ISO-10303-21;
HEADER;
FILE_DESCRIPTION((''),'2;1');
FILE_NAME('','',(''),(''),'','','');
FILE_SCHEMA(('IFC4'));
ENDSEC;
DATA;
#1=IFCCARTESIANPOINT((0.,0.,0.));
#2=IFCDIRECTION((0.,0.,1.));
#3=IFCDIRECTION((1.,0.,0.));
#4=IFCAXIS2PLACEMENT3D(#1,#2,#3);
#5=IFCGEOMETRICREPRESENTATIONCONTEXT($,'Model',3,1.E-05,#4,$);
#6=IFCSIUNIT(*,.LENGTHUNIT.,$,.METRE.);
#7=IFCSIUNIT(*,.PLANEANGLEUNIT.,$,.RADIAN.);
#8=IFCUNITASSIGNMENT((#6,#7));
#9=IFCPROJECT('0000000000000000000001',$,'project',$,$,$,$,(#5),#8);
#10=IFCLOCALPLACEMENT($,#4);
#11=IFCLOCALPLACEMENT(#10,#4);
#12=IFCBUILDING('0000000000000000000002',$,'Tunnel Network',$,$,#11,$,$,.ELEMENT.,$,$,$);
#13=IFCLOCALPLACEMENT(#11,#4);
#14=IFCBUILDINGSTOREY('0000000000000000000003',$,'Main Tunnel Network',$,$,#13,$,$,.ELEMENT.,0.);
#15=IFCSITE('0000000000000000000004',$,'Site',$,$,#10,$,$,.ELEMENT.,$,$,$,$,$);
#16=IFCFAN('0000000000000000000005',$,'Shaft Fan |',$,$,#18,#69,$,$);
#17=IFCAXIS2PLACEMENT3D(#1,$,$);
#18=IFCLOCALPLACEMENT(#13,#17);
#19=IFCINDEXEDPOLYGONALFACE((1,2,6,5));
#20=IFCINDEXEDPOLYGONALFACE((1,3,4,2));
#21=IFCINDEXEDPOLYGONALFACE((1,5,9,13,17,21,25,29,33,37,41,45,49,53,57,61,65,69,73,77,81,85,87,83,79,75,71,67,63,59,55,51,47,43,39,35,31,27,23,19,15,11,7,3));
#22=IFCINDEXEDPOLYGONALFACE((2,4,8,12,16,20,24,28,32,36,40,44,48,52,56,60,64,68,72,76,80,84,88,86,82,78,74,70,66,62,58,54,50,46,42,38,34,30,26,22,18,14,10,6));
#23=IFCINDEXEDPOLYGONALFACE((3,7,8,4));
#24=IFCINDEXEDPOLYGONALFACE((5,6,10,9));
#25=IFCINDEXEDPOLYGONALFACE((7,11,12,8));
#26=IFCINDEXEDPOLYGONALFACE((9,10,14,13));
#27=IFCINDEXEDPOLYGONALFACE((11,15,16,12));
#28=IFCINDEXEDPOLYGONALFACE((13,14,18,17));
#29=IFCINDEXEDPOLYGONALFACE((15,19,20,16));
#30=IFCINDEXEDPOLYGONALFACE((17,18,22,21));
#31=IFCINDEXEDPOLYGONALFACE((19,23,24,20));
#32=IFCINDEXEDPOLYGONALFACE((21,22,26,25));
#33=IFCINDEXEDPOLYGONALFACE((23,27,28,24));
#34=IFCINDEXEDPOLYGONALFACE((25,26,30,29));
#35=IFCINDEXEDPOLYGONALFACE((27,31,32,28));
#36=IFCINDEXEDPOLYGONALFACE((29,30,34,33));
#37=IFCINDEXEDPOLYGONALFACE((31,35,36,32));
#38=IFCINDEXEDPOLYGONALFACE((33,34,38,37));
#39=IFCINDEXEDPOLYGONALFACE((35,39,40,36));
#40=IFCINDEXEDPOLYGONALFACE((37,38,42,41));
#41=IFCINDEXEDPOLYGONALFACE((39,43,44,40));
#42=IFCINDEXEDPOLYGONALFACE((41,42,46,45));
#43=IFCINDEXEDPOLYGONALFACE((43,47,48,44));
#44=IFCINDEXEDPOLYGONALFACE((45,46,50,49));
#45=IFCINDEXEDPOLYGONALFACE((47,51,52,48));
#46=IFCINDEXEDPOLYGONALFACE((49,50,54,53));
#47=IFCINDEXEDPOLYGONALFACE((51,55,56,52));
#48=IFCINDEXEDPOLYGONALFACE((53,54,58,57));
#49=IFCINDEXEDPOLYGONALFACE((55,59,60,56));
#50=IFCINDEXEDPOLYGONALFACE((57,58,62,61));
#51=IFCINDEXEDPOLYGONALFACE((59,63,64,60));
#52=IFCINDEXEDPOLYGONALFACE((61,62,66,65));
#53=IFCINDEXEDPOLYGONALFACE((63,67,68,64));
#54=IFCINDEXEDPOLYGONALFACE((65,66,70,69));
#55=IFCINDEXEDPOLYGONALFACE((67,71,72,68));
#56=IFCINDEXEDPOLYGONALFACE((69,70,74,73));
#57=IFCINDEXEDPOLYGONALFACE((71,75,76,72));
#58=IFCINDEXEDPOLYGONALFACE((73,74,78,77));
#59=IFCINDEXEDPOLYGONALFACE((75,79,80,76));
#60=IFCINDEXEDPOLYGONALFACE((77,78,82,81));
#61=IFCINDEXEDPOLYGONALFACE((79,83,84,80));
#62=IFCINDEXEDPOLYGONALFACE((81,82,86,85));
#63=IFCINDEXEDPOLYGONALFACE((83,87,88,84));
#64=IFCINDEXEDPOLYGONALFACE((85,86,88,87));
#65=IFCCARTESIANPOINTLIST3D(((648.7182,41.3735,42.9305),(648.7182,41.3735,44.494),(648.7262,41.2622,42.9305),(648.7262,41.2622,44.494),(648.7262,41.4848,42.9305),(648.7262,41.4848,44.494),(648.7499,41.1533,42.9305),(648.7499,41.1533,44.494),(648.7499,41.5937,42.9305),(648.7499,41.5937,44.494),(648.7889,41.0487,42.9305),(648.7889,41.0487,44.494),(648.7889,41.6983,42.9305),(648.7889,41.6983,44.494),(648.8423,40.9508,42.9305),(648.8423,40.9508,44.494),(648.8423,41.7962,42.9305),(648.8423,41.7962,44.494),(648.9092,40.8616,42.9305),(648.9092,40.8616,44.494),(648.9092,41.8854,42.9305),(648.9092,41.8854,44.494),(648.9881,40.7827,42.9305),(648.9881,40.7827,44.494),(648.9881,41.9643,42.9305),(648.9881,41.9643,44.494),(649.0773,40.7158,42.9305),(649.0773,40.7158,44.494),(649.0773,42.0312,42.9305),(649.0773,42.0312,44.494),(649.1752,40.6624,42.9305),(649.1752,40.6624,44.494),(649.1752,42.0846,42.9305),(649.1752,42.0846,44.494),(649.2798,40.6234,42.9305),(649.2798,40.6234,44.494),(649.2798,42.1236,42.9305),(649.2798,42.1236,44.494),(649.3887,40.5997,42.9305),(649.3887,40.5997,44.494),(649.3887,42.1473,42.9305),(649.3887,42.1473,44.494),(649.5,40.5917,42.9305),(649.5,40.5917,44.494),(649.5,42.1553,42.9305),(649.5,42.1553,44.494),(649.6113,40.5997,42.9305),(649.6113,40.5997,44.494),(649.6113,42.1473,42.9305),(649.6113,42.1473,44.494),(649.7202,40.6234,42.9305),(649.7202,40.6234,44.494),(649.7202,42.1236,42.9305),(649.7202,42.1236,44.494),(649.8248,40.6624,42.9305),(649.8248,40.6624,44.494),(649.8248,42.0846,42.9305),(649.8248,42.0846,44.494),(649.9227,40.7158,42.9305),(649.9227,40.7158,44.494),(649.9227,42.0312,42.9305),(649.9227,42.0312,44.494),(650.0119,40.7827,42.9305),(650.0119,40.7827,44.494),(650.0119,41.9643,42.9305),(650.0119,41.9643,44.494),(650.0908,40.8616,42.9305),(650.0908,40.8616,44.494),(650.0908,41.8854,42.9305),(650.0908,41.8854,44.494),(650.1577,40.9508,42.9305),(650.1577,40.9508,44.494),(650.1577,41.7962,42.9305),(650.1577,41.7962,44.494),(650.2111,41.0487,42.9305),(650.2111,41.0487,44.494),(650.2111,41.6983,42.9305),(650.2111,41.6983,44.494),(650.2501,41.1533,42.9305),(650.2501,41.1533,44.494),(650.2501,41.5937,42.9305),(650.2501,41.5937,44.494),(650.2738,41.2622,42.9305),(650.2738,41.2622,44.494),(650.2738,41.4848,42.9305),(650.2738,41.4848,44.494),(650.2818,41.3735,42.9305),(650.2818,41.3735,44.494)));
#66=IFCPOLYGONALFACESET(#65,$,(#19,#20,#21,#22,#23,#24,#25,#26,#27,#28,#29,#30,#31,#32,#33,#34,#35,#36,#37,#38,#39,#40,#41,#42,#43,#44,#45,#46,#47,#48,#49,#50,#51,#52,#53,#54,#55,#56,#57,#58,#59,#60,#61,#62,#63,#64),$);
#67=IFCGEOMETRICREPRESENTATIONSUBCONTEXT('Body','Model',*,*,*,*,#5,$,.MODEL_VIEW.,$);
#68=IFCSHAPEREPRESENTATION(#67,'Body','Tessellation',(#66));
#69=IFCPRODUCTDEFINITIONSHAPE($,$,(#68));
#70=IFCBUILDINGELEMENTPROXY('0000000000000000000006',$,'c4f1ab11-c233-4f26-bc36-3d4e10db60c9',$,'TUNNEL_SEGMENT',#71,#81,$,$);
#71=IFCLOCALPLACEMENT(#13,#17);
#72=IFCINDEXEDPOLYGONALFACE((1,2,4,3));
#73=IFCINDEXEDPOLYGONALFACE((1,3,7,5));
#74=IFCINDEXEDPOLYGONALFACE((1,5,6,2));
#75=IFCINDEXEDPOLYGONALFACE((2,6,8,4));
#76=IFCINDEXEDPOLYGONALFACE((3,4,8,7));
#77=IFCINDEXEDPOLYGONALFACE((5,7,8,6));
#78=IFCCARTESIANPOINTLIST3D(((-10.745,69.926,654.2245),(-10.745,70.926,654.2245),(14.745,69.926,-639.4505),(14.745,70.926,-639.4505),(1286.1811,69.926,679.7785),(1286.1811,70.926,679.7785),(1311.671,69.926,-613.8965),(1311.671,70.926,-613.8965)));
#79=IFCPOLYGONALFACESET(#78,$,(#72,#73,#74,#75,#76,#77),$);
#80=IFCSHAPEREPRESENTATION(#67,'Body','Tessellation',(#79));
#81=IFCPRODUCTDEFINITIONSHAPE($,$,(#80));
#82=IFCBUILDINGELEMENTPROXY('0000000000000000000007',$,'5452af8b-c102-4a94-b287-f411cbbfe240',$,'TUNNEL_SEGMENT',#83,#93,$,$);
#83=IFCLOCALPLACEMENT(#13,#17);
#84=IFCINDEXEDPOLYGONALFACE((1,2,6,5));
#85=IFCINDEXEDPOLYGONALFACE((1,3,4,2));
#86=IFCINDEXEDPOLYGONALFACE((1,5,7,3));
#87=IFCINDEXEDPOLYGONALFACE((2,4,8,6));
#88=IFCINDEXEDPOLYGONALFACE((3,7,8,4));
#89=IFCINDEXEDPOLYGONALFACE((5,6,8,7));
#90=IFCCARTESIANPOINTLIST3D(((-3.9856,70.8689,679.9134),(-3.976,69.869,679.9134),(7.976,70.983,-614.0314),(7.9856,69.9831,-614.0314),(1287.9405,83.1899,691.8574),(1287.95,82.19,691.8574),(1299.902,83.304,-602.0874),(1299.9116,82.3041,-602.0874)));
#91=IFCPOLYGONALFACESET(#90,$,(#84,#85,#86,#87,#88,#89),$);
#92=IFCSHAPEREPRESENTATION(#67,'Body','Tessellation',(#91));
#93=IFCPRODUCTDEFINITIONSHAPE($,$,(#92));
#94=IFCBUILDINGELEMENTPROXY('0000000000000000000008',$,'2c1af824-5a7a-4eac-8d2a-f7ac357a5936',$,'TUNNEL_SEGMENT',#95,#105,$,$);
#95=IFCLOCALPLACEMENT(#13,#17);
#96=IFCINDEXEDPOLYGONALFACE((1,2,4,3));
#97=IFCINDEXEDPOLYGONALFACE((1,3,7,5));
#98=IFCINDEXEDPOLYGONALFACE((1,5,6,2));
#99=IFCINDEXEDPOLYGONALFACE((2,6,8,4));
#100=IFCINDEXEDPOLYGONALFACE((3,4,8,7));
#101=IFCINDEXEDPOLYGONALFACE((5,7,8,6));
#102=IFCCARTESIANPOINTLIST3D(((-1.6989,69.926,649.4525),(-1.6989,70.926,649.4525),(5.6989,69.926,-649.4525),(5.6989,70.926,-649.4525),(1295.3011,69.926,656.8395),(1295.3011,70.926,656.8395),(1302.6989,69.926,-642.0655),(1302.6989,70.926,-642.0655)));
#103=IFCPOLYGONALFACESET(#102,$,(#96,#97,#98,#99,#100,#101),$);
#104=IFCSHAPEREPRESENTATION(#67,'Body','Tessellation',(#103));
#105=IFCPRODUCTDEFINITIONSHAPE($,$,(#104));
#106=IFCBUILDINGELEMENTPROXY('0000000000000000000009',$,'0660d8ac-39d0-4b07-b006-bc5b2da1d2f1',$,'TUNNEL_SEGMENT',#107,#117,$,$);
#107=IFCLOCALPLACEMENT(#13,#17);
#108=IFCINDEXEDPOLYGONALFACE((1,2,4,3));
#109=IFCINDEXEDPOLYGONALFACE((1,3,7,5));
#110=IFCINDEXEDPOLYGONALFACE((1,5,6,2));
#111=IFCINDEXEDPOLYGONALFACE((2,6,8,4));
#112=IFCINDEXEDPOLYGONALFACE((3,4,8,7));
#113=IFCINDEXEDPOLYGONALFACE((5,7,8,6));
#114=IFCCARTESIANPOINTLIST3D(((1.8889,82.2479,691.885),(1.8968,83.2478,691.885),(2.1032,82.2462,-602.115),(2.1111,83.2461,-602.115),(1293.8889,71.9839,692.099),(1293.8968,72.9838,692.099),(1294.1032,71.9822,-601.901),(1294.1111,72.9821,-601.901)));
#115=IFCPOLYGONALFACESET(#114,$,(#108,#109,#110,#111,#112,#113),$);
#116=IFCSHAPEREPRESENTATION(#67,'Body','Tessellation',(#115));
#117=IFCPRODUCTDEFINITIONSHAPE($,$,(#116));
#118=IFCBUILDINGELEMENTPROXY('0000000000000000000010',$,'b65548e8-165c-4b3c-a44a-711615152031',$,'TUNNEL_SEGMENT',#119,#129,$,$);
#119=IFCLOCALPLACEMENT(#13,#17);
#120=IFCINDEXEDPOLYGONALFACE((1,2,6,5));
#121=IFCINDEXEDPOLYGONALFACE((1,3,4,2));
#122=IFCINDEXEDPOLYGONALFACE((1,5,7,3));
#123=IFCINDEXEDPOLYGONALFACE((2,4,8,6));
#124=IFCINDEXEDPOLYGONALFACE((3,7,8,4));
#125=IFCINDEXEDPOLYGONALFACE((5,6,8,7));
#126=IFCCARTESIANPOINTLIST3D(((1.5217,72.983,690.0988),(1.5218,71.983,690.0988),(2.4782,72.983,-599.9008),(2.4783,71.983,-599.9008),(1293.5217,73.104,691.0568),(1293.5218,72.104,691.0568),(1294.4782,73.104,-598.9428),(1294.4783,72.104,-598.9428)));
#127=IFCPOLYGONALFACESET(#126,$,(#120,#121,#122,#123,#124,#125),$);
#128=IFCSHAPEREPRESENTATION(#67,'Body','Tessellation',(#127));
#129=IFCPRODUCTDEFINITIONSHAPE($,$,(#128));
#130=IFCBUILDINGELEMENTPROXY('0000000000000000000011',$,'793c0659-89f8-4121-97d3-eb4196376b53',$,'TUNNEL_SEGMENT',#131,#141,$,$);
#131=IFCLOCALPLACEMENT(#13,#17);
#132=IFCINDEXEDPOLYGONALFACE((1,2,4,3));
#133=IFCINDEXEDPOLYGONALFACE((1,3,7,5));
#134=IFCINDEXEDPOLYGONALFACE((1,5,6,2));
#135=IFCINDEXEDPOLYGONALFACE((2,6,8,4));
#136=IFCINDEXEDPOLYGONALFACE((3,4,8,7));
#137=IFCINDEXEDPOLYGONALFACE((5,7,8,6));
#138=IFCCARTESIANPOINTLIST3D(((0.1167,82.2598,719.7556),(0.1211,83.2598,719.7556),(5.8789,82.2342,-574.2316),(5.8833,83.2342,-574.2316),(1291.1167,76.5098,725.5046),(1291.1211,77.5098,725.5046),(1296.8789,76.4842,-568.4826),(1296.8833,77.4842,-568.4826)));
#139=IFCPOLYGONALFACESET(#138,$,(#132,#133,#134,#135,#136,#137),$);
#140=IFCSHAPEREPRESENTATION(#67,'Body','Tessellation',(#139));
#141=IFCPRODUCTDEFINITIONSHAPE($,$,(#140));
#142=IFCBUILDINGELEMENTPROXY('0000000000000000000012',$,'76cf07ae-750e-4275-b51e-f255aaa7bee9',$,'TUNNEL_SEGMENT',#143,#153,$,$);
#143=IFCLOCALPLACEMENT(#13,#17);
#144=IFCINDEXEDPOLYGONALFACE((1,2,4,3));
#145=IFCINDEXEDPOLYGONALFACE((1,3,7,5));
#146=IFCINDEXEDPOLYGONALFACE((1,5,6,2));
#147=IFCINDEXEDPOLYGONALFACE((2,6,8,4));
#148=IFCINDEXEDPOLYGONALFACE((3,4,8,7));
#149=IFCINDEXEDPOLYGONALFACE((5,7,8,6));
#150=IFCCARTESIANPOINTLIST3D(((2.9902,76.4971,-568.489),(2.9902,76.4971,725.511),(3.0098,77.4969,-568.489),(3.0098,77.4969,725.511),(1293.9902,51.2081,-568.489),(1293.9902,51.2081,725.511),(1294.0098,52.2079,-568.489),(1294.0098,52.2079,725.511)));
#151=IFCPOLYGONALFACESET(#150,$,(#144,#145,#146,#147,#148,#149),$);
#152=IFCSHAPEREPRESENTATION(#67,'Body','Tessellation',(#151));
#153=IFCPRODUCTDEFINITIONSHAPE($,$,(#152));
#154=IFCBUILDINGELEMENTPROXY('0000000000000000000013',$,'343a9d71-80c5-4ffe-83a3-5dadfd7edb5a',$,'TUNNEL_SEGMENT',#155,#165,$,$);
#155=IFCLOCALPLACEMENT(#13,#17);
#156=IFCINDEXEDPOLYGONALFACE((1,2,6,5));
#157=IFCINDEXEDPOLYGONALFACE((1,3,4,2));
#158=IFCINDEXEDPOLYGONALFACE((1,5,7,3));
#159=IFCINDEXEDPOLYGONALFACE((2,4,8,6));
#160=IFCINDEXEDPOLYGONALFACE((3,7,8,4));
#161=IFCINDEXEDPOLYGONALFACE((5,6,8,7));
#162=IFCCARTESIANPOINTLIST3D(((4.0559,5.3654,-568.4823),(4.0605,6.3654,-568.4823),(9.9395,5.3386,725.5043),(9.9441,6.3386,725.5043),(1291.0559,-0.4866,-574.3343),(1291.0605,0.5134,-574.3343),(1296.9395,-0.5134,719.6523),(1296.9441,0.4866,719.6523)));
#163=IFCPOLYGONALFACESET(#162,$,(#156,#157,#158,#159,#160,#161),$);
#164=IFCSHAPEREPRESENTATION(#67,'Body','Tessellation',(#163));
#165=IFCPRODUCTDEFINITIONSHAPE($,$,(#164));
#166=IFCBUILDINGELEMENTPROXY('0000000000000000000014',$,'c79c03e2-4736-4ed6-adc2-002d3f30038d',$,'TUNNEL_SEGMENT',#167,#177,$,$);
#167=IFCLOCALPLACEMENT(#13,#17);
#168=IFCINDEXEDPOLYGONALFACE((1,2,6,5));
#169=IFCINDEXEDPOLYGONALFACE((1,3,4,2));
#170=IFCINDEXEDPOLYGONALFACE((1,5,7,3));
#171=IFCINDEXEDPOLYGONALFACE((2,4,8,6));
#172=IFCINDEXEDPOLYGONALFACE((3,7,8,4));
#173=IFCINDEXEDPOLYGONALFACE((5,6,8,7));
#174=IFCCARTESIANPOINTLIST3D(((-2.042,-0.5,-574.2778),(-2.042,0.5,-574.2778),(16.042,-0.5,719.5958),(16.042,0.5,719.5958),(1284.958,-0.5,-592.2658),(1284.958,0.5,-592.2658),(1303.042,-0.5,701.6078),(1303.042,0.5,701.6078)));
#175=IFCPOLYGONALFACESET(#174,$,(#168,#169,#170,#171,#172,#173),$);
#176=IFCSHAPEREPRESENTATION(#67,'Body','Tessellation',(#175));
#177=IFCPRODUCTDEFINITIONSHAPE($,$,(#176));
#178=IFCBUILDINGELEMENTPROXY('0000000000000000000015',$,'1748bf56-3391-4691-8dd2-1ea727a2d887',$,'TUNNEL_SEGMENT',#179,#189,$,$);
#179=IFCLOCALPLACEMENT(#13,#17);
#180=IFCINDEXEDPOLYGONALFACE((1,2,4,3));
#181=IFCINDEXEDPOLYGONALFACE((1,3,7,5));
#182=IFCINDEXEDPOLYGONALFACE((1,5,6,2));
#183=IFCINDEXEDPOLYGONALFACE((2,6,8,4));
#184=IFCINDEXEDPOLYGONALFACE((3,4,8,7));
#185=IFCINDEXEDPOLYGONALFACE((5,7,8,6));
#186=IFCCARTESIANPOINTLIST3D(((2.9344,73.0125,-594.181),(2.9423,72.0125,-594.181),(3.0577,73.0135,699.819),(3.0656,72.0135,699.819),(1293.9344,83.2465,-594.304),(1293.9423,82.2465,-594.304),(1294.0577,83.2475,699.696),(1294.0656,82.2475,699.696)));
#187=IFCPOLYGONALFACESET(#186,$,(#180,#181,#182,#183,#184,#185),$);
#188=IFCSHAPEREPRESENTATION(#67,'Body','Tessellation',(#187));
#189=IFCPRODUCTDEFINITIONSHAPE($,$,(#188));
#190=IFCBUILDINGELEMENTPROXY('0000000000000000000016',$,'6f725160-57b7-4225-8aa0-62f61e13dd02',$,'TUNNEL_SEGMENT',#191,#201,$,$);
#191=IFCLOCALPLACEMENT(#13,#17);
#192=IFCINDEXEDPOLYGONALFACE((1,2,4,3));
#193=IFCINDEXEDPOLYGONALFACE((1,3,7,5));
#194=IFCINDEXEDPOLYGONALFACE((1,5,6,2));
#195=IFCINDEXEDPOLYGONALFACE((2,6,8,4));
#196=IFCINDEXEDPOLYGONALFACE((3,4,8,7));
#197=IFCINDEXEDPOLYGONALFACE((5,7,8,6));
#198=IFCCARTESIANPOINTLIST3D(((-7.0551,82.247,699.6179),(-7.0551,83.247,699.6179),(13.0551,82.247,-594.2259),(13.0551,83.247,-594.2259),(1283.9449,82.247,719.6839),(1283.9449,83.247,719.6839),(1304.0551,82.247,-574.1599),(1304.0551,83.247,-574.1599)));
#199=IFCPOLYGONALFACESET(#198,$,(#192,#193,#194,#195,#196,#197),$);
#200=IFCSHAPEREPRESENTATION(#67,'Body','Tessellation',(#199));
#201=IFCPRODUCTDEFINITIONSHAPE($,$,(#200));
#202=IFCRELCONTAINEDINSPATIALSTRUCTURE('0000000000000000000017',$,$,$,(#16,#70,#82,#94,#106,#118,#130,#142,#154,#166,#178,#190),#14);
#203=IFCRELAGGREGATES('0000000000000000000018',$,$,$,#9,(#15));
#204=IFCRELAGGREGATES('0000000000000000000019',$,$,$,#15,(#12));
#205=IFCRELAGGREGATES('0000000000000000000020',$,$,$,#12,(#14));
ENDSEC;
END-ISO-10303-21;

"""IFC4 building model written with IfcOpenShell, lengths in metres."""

from ifc_helpers import new_model, si_unit, frame, origin_with_axes, origin_2d_with_axis, place, context, subcontext, project, spatial, rectangle, circle, extrude, element, save


model = new_model("IFC4")

# Units and contexts
model_context = context("Model", 3, precision=1e-05, world=origin_with_axes())
body_context = subcontext(model_context, "Body", "Model", "MODEL_VIEW")
ifc_project = project(units=[si_unit("LENGTHUNIT", "METRE"), si_unit("PLANEANGLEUNIT", "RADIAN")], contexts=[model_context])

# Site, building, storey
site_placement = place(None, origin_with_axes())
site = spatial("IfcSite", under=ifc_project, at=site_placement, Name="Site", CompositionType="ELEMENT")
building_placement = place(site_placement, origin_with_axes())
building = spatial("IfcBuilding", under=site, at=building_placement, Name="Tunnel Network", CompositionType="ELEMENT")
storey_placement = place(building_placement, origin_with_axes())
storey = spatial("IfcBuildingStorey", under=building, at=storey_placement, Name="Main Tunnel Network", CompositionType="ELEMENT", Elevation=0.0)

# Fan
fan_1_placement = place(storey_placement, frame((649.5, 41.3735, 42.9305), z_axis=(0.0, 0.0, 1.0), x_axis=(1.0, 0.0, 0.0)))
element("IfcFan", 1, at=fan_1_placement, inside=storey, Name="Shaft Fan |", context=body_context, shape_type="SweptSolid", body=[
    extrude(circle(Radius=0.7818, at=origin_2d_with_axis()), origin_with_axes(), (0.0, 0.0, 1.0), 1.5635),
])

# Building element proxies
proxy_1_placement = place(storey_placement, frame((2.0, 70.426, 7.387), z_axis=(0.999806, 0.0, 0.0197), x_axis=(-0.0197, 0.0, 0.999806)))
element("IfcBuildingElementProxy", 2, at=proxy_1_placement, inside=storey, Name="c4f1ab11-c233-4f26-bc36-3d4e10db60c9", ObjectType="TUNNEL_SEGMENT", context=body_context, shape_type="SweptSolid", body=[
    extrude(rectangle(XDim=1293.926, YDim=1.0, at=origin_2d_with_axis()), origin_with_axes(), (0.0, 0.0, 1.0), 1297.1778),
])
proxy_2_placement = place(storey_placement, frame((2.0, 70.426, 32.941), z_axis=(0.999912, 0.009536, 0.009244), x_axis=(-0.009244, -0.000088, 0.999957)))
element("IfcBuildingElementProxy", 3, at=proxy_2_placement, inside=storey, Name="5452af8b-c102-4a94-b287-f411cbbfe240", ObjectType="TUNNEL_SEGMENT", context=body_context, shape_type="SweptSolid", body=[
    extrude(rectangle(XDim=1294.0, YDim=1.0, at=origin_2d_with_axis()), origin_with_axes(), (0.0, 0.0, 1.0), 1292.04),
])
proxy_3_placement = place(storey_placement, frame((2.0, 70.426, 0.0), z_axis=(0.999984, 0.0, 0.005695), x_axis=(-0.005695, 0.0, 0.999984)))
element("IfcBuildingElementProxy", 4, at=proxy_3_placement, inside=storey, Name="2c1af824-5a7a-4eac-8d2a-f7ac357a5936", ObjectType="TUNNEL_SEGMENT", context=body_context, shape_type="SweptSolid", body=[
    extrude(rectangle(XDim=1298.926, YDim=1.0, at=origin_2d_with_axis()), origin_with_axes(), (0.0, 0.0, 1.0), 1297.021),
])
proxy_4_placement = place(storey_placement, frame((2.0, 82.747, 44.885), z_axis=(0.999968, -0.007944, 0.000166), x_axis=(-0.000166, 0.000001, 1.0)))
element("IfcBuildingElementProxy", 5, at=proxy_4_placement, inside=storey, Name="0660d8ac-39d0-4b07-b006-bc5b2da1d2f1", ObjectType="TUNNEL_SEGMENT", context=body_context, shape_type="SweptSolid", body=[
    extrude(rectangle(XDim=1294.0, YDim=1.0, at=origin_2d_with_axis()), origin_with_axes(), (0.0, 0.0, 1.0), 1292.0408),
])
proxy_5_placement = place(storey_placement, frame((2.0, 72.483, 45.099), z_axis=(1.0, 0.000094, 0.000741), x_axis=(-0.000741, 0.0, 1.0)))
element("IfcBuildingElementProxy", 6, at=proxy_5_placement, inside=storey, Name="b65548e8-165c-4b3c-a44a-711615152031", ObjectType="TUNNEL_SEGMENT", context=body_context, shape_type="SweptSolid", body=[
    extrude(rectangle(XDim=1290.0, YDim=1.0, at=origin_2d_with_axis()), origin_with_axes(), (0.0, 0.0, 1.0), 1292.0004),
])
proxy_6_placement = place(storey_placement, frame((3.0, 82.747, 72.762), z_axis=(0.99998, -0.004454, 0.004453), x_axis=(-0.004453, 0.00002, 0.99999)))
element("IfcBuildingElementProxy", 7, at=proxy_6_placement, inside=storey, Name="793c0659-89f8-4121-97d3-eb4196376b53", ObjectType="TUNNEL_SEGMENT", context=body_context, shape_type="SweptSolid", body=[
    extrude(rectangle(XDim=1294.0, YDim=1.0, at=origin_2d_with_axis()), origin_with_axes(), (0.0, 0.0, 1.0), 1291.0256),
])
proxy_7_placement = place(storey_placement, frame((3.0, 76.997, 78.511), z_axis=(0.999808, -0.019585, 0.0), x_axis=(0.0, 0.0, 1.0)))
element("IfcBuildingElementProxy", 8, at=proxy_7_placement, inside=storey, Name="76cf07ae-750e-4275-b51e-f255aaa7bee9", ObjectType="TUNNEL_SEGMENT", context=body_context, shape_type="SweptSolid", body=[
    extrude(rectangle(XDim=1294.0, YDim=1.0, at=origin_2d_with_axis()), origin_with_axes(), (0.0, 0.0, 1.0), 1291.2477),
])
proxy_8_placement = place(storey_placement, frame((7.0, 5.852, 78.511), z_axis=(0.999979, -0.004547, -0.004547), x_axis=(0.004547, -0.000021, 0.99999)))
element("IfcBuildingElementProxy", 9, at=proxy_8_placement, inside=storey, Name="343a9d71-80c5-4ffe-83a3-5dadfd7edb5a", ObjectType="TUNNEL_SEGMENT", context=body_context, shape_type="SweptSolid", body=[
    extrude(rectangle(XDim=1294.0, YDim=1.0, at=origin_2d_with_axis()), origin_with_axes(), (0.0, 0.0, 1.0), 1287.0266),
])
proxy_9_placement = place(storey_placement, frame((7.0, 0.0, 72.659), z_axis=(0.999902, 0.0, -0.013975), x_axis=(0.013975, 0.0, 0.999902)))
element("IfcBuildingElementProxy", 10, at=proxy_9_placement, inside=storey, Name="c79c03e2-4736-4ed6-adc2-002d3f30038d", ObjectType="TUNNEL_SEGMENT", context=body_context, shape_type="SweptSolid", body=[
    extrude(rectangle(XDim=1294.0, YDim=1.0, at=origin_2d_with_axis()), origin_with_axes(), (0.0, 0.0, 1.0), 1287.1257),
])
proxy_10_placement = place(storey_placement, frame((3.0, 72.513, 52.819), z_axis=(0.999969, 0.007927, -0.000095), x_axis=(0.000095, 0.000001, 1.0)))
element("IfcBuildingElementProxy", 11, at=proxy_10_placement, inside=storey, Name="1748bf56-3391-4691-8dd2-1ea727a2d887", ObjectType="TUNNEL_SEGMENT", context=body_context, shape_type="SweptSolid", body=[
    extrude(rectangle(XDim=1294.0, YDim=1.0, at=origin_2d_with_axis()), origin_with_axes(), (0.0, 0.0, 1.0), 1291.0406),
])
proxy_11_placement = place(storey_placement, frame((3.0, 82.747, 52.696), z_axis=(0.999879, 0.0, 0.015541), x_axis=(-0.015541, 0.0, 0.999879)))
element("IfcBuildingElementProxy", 12, at=proxy_11_placement, inside=storey, Name="6f725160-57b7-4225-8aa0-62f61e13dd02", ObjectType="TUNNEL_SEGMENT", context=body_context, shape_type="SweptSolid", body=[
    extrude(rectangle(XDim=1294.0, YDim=1.0, at=origin_2d_with_axis()), origin_with_axes(), (0.0, 0.0, 1.0), 1291.1559),
])

save(model, "model.ifc")
